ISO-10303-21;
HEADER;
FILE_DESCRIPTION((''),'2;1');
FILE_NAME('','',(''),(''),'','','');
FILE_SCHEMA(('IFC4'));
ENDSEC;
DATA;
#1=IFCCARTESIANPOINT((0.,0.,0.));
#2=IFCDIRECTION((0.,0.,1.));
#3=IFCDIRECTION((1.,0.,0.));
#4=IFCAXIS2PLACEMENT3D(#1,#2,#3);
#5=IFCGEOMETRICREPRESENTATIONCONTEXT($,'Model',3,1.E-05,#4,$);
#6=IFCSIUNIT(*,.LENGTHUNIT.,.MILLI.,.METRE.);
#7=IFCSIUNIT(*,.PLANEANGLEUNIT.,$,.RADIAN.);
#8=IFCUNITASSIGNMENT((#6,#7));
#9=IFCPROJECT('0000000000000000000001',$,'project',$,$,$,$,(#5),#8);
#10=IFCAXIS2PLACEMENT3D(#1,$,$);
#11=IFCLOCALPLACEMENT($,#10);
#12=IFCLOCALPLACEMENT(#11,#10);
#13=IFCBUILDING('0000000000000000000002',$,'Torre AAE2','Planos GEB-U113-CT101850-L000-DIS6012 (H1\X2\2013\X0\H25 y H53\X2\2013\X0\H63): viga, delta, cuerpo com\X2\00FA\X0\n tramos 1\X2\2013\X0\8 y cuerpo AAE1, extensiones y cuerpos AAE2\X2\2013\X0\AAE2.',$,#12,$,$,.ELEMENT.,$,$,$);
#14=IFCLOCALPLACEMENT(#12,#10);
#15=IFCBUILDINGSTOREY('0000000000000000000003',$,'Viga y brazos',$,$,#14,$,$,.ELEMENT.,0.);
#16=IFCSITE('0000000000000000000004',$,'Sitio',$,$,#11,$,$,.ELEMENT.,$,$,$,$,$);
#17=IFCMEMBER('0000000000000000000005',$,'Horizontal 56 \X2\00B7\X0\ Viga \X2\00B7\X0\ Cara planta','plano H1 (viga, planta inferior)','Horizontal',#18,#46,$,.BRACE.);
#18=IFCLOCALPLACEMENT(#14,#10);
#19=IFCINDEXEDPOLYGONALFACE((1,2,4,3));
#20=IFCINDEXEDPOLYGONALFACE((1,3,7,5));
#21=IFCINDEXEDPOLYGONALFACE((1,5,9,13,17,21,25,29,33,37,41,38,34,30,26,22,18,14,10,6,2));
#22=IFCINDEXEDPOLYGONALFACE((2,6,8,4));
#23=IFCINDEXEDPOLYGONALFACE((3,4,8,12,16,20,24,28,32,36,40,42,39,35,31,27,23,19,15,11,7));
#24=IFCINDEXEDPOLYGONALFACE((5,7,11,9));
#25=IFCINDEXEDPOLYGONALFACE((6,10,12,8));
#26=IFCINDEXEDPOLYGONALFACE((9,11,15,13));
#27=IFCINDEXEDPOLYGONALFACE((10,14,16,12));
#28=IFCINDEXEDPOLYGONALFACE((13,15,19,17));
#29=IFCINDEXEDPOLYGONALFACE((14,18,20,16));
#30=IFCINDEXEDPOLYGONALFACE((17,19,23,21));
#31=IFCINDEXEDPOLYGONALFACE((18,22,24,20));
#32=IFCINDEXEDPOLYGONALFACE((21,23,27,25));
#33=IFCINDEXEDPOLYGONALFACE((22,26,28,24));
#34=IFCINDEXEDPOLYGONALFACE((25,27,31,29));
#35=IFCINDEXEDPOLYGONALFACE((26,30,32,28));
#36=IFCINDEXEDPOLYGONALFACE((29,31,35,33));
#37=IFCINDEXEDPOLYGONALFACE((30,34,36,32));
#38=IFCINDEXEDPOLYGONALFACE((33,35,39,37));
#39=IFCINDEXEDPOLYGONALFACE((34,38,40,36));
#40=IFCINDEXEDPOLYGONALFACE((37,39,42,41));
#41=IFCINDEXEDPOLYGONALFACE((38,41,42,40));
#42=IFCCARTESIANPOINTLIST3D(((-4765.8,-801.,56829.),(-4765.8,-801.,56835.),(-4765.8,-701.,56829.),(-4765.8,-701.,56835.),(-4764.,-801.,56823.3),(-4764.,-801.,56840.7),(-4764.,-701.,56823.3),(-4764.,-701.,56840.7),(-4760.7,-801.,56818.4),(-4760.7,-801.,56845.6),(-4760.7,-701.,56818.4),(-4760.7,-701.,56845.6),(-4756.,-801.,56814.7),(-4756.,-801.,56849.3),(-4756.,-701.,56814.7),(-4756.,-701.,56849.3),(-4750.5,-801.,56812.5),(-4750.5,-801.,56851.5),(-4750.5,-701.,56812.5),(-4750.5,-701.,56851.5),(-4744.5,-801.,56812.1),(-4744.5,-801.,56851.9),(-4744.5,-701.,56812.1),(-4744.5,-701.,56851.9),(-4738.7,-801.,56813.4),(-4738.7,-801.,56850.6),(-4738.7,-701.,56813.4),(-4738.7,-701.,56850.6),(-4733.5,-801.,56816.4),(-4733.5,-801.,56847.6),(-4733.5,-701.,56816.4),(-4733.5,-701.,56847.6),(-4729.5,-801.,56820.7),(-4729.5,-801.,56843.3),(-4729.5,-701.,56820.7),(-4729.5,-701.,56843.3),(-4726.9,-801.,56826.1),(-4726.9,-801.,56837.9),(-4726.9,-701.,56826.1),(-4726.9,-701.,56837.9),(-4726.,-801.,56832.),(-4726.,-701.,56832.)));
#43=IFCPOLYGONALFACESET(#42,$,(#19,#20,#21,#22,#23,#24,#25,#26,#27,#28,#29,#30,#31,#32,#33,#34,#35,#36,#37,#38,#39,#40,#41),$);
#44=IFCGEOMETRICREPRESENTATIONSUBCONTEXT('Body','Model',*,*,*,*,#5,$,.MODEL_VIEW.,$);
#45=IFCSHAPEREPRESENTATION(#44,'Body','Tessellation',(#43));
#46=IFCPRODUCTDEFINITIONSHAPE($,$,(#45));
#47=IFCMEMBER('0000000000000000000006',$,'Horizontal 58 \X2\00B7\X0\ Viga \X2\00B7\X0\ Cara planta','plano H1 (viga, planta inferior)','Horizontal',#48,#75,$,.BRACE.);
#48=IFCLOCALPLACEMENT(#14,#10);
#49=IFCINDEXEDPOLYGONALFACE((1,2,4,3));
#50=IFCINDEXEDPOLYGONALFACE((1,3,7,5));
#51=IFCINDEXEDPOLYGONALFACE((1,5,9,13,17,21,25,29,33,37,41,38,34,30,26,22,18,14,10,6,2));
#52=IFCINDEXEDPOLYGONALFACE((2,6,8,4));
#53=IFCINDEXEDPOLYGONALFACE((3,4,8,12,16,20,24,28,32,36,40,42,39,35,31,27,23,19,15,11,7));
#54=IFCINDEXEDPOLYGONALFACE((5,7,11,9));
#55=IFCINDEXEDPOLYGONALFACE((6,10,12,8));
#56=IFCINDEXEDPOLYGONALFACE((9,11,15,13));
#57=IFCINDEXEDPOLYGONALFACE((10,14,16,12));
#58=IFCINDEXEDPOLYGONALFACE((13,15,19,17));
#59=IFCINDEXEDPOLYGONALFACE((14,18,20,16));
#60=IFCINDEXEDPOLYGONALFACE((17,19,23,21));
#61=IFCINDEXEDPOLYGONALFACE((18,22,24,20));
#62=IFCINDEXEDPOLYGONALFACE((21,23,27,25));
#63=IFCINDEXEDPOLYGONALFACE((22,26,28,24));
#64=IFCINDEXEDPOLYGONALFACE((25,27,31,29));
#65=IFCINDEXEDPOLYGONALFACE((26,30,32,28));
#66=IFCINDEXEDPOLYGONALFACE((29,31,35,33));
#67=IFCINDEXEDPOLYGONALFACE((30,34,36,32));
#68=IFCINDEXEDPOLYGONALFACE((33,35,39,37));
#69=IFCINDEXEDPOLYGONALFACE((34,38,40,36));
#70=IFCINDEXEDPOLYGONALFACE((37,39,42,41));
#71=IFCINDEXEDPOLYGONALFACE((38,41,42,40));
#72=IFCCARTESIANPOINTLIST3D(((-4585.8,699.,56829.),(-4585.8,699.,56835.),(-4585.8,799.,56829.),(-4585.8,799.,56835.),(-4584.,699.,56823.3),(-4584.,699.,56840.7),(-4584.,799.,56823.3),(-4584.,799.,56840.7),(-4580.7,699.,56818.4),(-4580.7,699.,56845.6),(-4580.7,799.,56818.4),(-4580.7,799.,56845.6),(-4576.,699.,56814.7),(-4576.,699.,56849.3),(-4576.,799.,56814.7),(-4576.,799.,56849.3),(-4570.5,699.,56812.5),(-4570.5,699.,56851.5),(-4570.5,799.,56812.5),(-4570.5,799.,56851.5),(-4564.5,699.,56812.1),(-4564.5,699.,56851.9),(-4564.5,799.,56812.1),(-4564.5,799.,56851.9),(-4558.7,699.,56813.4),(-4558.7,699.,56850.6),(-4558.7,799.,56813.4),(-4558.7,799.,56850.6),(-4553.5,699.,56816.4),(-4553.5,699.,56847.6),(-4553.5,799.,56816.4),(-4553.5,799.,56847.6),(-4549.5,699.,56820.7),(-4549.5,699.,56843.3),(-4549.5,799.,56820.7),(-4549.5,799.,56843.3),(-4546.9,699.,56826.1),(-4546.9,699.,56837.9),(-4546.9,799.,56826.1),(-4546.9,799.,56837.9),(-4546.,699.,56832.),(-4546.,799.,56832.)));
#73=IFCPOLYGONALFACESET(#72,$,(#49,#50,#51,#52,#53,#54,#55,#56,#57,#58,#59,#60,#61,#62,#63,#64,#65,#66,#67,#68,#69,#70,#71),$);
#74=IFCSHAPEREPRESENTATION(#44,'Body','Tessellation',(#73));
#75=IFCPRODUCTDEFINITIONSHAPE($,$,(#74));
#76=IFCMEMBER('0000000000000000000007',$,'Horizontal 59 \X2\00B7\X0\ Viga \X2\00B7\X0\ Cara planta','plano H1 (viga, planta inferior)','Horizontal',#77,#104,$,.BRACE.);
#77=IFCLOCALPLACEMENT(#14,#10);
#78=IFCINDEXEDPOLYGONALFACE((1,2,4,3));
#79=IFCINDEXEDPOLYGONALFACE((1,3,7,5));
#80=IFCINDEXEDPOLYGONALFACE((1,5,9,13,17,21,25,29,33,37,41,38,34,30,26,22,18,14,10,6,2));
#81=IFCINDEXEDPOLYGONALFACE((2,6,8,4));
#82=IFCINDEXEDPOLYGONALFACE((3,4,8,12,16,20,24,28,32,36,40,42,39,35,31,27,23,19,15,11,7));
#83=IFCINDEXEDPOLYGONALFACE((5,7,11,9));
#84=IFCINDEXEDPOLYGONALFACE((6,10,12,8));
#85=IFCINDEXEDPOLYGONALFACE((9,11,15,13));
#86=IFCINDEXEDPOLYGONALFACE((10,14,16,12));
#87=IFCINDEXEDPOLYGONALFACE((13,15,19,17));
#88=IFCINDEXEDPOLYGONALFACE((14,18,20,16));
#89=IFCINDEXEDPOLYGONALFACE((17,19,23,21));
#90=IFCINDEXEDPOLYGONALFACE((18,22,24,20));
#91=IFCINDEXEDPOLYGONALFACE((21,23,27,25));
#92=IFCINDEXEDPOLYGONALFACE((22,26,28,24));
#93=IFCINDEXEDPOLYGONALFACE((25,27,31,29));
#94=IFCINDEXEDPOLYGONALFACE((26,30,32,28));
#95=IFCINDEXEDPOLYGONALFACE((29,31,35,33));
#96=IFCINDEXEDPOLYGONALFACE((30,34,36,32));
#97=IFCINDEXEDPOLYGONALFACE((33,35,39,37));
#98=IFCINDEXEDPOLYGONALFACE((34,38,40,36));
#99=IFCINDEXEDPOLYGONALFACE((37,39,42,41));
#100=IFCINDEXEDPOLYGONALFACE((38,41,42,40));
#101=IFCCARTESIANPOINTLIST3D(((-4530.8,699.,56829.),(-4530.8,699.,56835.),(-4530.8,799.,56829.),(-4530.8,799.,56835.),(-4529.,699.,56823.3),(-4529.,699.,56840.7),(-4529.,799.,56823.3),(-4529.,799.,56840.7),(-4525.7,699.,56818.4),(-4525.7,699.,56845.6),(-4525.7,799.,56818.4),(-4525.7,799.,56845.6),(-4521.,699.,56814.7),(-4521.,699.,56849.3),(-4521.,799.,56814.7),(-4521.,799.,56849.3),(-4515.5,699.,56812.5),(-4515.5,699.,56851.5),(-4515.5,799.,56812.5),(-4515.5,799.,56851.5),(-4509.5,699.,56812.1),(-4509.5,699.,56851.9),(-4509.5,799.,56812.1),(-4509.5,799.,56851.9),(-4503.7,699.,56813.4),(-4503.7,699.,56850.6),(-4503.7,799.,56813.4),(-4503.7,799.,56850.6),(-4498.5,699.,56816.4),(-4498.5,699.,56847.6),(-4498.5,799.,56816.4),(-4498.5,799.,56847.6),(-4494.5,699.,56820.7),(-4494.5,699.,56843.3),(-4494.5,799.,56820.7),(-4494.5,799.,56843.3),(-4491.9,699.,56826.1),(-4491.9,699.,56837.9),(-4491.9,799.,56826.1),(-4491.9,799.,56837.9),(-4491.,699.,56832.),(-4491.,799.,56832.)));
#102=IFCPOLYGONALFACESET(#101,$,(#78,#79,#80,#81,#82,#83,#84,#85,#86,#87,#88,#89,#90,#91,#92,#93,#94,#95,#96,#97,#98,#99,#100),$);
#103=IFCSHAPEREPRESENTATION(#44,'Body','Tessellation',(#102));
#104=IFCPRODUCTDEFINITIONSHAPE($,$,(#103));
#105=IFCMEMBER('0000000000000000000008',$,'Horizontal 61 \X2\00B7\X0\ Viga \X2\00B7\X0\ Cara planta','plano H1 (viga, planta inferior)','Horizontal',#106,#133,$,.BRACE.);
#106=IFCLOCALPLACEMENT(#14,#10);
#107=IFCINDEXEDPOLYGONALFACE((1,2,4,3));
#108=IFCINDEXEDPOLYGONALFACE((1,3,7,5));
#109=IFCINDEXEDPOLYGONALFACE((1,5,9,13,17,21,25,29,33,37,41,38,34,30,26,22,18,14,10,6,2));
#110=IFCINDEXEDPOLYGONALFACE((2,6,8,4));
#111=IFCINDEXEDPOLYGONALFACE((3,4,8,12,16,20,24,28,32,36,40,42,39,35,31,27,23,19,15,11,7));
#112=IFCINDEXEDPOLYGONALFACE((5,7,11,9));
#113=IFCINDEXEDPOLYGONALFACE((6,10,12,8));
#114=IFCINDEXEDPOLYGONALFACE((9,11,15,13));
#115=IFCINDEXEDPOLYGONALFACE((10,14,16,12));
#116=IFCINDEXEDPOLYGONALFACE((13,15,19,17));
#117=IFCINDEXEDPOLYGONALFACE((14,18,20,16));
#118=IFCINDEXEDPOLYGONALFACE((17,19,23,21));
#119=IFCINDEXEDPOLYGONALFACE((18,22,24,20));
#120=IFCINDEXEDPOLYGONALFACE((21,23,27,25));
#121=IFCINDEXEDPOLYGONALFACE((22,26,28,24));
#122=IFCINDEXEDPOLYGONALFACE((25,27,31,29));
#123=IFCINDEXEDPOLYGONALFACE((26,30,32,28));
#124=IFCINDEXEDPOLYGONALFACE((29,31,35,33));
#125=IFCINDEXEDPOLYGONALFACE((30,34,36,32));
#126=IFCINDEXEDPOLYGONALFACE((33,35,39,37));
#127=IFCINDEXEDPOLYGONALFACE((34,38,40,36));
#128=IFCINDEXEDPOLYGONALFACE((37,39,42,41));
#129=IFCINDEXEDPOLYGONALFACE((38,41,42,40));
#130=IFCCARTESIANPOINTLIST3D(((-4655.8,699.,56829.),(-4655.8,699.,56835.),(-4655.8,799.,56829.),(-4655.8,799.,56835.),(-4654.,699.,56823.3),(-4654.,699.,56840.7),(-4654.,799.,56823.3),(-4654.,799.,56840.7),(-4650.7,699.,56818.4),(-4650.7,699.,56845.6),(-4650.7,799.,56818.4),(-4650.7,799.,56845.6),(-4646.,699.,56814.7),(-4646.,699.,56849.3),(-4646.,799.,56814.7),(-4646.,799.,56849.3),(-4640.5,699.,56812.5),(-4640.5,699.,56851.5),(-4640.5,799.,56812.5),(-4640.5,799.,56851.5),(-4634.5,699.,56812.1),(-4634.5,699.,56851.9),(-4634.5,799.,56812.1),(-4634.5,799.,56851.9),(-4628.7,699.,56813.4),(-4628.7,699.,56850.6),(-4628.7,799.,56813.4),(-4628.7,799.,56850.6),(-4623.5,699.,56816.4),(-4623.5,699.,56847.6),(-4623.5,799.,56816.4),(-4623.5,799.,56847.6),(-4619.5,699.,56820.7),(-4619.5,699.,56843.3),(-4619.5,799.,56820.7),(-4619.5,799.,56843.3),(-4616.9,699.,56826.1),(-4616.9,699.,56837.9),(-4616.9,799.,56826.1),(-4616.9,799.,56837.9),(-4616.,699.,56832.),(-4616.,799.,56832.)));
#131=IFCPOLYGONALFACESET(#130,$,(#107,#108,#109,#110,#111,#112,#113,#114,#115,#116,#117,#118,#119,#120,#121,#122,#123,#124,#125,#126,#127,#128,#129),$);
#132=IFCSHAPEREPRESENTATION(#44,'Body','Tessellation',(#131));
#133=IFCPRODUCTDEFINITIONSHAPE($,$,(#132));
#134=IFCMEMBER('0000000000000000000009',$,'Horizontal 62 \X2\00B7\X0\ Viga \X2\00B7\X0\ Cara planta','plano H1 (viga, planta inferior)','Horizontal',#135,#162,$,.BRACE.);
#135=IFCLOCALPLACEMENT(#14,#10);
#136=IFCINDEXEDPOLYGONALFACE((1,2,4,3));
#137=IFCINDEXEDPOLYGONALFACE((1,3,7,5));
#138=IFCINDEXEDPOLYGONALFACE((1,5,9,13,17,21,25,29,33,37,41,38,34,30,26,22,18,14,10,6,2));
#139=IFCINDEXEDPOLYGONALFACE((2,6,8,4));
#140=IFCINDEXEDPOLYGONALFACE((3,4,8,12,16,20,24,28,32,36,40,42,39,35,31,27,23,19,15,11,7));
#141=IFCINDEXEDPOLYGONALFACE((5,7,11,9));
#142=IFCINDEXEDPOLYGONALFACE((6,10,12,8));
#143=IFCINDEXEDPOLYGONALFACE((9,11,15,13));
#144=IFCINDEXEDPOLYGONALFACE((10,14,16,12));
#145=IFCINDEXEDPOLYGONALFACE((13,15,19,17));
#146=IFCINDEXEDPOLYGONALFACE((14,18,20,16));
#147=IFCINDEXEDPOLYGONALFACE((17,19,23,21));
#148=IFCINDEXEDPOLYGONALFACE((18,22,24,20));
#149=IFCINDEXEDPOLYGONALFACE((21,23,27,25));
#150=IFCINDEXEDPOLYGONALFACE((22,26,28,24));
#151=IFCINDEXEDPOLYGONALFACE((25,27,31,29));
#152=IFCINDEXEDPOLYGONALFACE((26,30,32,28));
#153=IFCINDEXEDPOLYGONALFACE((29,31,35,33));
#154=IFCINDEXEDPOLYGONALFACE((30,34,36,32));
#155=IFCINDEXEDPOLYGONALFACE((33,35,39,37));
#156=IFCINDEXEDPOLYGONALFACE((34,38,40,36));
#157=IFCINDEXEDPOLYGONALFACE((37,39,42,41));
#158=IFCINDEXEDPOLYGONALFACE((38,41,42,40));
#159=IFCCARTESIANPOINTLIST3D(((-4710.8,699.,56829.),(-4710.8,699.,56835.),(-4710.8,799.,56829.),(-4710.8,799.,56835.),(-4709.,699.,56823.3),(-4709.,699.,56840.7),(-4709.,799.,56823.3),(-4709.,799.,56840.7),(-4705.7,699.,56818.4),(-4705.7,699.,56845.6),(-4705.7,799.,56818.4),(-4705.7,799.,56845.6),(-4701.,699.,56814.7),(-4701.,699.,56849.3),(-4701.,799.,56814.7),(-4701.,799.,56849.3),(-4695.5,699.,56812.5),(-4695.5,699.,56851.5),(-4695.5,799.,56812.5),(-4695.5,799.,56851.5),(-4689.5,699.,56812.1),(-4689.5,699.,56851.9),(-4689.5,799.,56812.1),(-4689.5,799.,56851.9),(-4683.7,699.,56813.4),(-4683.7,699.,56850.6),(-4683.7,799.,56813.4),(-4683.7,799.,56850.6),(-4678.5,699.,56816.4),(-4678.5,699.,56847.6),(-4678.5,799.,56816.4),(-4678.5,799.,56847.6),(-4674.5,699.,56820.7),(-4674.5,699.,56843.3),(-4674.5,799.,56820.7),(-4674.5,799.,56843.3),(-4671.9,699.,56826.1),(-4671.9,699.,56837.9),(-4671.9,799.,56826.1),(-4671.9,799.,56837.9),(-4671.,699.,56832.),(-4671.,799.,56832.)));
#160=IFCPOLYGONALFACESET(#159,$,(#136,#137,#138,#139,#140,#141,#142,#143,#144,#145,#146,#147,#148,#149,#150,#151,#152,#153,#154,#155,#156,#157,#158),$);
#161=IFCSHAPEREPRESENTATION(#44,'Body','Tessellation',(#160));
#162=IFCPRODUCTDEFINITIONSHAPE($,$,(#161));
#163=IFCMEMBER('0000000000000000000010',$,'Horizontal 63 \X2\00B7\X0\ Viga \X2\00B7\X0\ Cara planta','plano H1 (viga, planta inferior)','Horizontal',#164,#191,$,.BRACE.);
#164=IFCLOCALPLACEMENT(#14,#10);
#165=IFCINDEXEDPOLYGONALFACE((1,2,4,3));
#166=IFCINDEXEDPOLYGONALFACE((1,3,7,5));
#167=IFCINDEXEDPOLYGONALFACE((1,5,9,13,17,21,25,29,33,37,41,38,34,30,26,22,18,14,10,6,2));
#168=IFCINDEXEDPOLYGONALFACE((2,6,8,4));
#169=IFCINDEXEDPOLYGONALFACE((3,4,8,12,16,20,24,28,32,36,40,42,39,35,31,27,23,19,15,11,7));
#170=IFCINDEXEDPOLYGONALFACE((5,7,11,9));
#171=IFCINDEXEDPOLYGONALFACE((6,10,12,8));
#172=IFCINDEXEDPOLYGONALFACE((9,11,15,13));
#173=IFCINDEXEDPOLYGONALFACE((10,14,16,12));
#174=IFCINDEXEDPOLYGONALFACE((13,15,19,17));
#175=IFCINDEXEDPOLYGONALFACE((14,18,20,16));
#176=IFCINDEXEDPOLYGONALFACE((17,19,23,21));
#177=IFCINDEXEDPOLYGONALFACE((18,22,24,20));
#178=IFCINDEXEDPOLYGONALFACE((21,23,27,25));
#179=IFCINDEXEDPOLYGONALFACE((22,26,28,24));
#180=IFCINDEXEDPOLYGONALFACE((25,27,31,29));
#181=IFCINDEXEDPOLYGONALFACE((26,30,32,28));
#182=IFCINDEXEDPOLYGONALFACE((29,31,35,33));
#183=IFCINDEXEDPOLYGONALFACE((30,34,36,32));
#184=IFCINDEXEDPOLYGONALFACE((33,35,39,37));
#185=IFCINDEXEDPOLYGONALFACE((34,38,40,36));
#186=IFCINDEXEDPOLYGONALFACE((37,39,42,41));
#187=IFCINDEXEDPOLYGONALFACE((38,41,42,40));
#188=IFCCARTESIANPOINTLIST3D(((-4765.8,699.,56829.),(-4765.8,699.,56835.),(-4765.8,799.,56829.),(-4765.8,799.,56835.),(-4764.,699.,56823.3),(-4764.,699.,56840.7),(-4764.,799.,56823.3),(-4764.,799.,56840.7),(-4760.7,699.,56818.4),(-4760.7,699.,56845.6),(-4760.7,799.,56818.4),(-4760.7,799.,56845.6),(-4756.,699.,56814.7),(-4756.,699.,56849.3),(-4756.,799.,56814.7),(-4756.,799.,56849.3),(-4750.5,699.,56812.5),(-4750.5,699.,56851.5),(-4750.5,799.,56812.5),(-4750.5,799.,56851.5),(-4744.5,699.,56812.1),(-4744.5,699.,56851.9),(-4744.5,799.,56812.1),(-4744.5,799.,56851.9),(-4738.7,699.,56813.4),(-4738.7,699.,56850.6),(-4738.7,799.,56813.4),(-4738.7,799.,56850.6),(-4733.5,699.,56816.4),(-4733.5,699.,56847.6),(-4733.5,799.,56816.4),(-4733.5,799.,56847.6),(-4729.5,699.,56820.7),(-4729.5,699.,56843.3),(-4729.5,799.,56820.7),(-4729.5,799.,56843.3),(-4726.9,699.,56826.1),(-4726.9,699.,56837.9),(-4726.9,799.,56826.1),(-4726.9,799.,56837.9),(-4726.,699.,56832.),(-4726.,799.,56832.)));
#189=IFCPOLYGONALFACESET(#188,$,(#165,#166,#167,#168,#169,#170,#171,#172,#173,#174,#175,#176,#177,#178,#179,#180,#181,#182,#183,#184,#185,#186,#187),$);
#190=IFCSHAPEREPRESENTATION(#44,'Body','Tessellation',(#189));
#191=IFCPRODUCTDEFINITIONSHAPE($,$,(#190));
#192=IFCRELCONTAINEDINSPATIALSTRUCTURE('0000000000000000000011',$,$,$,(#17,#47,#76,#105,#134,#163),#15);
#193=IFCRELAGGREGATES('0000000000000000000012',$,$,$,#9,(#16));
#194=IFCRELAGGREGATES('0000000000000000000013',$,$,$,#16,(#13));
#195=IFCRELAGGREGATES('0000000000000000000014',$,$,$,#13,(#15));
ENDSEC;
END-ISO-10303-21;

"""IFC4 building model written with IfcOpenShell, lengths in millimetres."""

from ifc_helpers import new_model, si_unit, frame, origin, origin_with_axes, place, context, subcontext, project, spatial, circle, extrude, element, save


model = new_model("IFC4")

# Units and contexts
model_context = context("Model", 3, precision=1e-05, world=origin_with_axes())
body_context = subcontext(model_context, "Body", "Model", "MODEL_VIEW")
ifc_project = project(units=[si_unit("LENGTHUNIT", "METRE", prefix="MILLI"), si_unit("PLANEANGLEUNIT", "RADIAN")], contexts=[model_context])

# Site, building, storey
site_placement = place(None, origin())
site = spatial("IfcSite", under=ifc_project, at=site_placement, Name="Sitio", CompositionType="ELEMENT")
building_placement = place(site_placement, origin())
building = spatial("IfcBuilding", under=site, at=building_placement, Name="Torre AAE2", Description="Planos GEB-U113-CT101850-L000-DIS6012 (H1–H25 y H53–H63): viga, delta, cuerpo común tramos 1–8 y cuerpo AAE1, extensiones y cuerpos AAE2–AAE2.", CompositionType="ELEMENT")
storey_placement = place(building_placement, origin())
storey = spatial("IfcBuildingStorey", under=building, at=storey_placement, Name="Viga y brazos", CompositionType="ELEMENT", Elevation=0.0)

# Members
for number, where, z_axis, x_axis, name in (
    (1, (-4746.0, -701.0, 56832.0), (0.0, -1.0, 0.0), (1.0, 0.0, 0.0), "Horizontal 56 · Viga · Cara planta"),
    (2, (-4566.0, 699.0, 56832.0), (0.0, 1.0, 0.0), (1.0, 0.0, 0.0), "Horizontal 58 · Viga · Cara planta"),
    (3, (-4511.0, 699.0, 56832.0), (0.0, 1.0, 0.0), (1.0, 0.0, 0.0), "Horizontal 59 · Viga · Cara planta"),
    (4, (-4636.0, 699.0, 56832.0), (0.0, 1.0, 0.0), (1.0, 0.0, 0.0), "Horizontal 61 · Viga · Cara planta"),
    (5, (-4691.0, 699.0, 56832.0), (0.0, 1.0, 0.0), (1.0, 0.0, 0.0), "Horizontal 62 · Viga · Cara planta"),
    (6, (-4746.0, 699.0, 56832.0), (0.0, 1.0, 0.0), (1.0, 0.0, 0.0), "Horizontal 63 · Viga · Cara planta"),
):
    element("IfcMember", number, at=place(storey_placement, frame(where, z_axis=z_axis, x_axis=x_axis)), inside=storey, Name=name, Description="plano H1 (viga, planta inferior)", ObjectType="Horizontal", PredefinedType="BRACE", context=body_context, shape_type="SweptSolid", body=[
        extrude(circle(Radius=20.0), None, (0.0, 0.0, 1.0), 100.0),
    ])

save(model, "model.ifc")
